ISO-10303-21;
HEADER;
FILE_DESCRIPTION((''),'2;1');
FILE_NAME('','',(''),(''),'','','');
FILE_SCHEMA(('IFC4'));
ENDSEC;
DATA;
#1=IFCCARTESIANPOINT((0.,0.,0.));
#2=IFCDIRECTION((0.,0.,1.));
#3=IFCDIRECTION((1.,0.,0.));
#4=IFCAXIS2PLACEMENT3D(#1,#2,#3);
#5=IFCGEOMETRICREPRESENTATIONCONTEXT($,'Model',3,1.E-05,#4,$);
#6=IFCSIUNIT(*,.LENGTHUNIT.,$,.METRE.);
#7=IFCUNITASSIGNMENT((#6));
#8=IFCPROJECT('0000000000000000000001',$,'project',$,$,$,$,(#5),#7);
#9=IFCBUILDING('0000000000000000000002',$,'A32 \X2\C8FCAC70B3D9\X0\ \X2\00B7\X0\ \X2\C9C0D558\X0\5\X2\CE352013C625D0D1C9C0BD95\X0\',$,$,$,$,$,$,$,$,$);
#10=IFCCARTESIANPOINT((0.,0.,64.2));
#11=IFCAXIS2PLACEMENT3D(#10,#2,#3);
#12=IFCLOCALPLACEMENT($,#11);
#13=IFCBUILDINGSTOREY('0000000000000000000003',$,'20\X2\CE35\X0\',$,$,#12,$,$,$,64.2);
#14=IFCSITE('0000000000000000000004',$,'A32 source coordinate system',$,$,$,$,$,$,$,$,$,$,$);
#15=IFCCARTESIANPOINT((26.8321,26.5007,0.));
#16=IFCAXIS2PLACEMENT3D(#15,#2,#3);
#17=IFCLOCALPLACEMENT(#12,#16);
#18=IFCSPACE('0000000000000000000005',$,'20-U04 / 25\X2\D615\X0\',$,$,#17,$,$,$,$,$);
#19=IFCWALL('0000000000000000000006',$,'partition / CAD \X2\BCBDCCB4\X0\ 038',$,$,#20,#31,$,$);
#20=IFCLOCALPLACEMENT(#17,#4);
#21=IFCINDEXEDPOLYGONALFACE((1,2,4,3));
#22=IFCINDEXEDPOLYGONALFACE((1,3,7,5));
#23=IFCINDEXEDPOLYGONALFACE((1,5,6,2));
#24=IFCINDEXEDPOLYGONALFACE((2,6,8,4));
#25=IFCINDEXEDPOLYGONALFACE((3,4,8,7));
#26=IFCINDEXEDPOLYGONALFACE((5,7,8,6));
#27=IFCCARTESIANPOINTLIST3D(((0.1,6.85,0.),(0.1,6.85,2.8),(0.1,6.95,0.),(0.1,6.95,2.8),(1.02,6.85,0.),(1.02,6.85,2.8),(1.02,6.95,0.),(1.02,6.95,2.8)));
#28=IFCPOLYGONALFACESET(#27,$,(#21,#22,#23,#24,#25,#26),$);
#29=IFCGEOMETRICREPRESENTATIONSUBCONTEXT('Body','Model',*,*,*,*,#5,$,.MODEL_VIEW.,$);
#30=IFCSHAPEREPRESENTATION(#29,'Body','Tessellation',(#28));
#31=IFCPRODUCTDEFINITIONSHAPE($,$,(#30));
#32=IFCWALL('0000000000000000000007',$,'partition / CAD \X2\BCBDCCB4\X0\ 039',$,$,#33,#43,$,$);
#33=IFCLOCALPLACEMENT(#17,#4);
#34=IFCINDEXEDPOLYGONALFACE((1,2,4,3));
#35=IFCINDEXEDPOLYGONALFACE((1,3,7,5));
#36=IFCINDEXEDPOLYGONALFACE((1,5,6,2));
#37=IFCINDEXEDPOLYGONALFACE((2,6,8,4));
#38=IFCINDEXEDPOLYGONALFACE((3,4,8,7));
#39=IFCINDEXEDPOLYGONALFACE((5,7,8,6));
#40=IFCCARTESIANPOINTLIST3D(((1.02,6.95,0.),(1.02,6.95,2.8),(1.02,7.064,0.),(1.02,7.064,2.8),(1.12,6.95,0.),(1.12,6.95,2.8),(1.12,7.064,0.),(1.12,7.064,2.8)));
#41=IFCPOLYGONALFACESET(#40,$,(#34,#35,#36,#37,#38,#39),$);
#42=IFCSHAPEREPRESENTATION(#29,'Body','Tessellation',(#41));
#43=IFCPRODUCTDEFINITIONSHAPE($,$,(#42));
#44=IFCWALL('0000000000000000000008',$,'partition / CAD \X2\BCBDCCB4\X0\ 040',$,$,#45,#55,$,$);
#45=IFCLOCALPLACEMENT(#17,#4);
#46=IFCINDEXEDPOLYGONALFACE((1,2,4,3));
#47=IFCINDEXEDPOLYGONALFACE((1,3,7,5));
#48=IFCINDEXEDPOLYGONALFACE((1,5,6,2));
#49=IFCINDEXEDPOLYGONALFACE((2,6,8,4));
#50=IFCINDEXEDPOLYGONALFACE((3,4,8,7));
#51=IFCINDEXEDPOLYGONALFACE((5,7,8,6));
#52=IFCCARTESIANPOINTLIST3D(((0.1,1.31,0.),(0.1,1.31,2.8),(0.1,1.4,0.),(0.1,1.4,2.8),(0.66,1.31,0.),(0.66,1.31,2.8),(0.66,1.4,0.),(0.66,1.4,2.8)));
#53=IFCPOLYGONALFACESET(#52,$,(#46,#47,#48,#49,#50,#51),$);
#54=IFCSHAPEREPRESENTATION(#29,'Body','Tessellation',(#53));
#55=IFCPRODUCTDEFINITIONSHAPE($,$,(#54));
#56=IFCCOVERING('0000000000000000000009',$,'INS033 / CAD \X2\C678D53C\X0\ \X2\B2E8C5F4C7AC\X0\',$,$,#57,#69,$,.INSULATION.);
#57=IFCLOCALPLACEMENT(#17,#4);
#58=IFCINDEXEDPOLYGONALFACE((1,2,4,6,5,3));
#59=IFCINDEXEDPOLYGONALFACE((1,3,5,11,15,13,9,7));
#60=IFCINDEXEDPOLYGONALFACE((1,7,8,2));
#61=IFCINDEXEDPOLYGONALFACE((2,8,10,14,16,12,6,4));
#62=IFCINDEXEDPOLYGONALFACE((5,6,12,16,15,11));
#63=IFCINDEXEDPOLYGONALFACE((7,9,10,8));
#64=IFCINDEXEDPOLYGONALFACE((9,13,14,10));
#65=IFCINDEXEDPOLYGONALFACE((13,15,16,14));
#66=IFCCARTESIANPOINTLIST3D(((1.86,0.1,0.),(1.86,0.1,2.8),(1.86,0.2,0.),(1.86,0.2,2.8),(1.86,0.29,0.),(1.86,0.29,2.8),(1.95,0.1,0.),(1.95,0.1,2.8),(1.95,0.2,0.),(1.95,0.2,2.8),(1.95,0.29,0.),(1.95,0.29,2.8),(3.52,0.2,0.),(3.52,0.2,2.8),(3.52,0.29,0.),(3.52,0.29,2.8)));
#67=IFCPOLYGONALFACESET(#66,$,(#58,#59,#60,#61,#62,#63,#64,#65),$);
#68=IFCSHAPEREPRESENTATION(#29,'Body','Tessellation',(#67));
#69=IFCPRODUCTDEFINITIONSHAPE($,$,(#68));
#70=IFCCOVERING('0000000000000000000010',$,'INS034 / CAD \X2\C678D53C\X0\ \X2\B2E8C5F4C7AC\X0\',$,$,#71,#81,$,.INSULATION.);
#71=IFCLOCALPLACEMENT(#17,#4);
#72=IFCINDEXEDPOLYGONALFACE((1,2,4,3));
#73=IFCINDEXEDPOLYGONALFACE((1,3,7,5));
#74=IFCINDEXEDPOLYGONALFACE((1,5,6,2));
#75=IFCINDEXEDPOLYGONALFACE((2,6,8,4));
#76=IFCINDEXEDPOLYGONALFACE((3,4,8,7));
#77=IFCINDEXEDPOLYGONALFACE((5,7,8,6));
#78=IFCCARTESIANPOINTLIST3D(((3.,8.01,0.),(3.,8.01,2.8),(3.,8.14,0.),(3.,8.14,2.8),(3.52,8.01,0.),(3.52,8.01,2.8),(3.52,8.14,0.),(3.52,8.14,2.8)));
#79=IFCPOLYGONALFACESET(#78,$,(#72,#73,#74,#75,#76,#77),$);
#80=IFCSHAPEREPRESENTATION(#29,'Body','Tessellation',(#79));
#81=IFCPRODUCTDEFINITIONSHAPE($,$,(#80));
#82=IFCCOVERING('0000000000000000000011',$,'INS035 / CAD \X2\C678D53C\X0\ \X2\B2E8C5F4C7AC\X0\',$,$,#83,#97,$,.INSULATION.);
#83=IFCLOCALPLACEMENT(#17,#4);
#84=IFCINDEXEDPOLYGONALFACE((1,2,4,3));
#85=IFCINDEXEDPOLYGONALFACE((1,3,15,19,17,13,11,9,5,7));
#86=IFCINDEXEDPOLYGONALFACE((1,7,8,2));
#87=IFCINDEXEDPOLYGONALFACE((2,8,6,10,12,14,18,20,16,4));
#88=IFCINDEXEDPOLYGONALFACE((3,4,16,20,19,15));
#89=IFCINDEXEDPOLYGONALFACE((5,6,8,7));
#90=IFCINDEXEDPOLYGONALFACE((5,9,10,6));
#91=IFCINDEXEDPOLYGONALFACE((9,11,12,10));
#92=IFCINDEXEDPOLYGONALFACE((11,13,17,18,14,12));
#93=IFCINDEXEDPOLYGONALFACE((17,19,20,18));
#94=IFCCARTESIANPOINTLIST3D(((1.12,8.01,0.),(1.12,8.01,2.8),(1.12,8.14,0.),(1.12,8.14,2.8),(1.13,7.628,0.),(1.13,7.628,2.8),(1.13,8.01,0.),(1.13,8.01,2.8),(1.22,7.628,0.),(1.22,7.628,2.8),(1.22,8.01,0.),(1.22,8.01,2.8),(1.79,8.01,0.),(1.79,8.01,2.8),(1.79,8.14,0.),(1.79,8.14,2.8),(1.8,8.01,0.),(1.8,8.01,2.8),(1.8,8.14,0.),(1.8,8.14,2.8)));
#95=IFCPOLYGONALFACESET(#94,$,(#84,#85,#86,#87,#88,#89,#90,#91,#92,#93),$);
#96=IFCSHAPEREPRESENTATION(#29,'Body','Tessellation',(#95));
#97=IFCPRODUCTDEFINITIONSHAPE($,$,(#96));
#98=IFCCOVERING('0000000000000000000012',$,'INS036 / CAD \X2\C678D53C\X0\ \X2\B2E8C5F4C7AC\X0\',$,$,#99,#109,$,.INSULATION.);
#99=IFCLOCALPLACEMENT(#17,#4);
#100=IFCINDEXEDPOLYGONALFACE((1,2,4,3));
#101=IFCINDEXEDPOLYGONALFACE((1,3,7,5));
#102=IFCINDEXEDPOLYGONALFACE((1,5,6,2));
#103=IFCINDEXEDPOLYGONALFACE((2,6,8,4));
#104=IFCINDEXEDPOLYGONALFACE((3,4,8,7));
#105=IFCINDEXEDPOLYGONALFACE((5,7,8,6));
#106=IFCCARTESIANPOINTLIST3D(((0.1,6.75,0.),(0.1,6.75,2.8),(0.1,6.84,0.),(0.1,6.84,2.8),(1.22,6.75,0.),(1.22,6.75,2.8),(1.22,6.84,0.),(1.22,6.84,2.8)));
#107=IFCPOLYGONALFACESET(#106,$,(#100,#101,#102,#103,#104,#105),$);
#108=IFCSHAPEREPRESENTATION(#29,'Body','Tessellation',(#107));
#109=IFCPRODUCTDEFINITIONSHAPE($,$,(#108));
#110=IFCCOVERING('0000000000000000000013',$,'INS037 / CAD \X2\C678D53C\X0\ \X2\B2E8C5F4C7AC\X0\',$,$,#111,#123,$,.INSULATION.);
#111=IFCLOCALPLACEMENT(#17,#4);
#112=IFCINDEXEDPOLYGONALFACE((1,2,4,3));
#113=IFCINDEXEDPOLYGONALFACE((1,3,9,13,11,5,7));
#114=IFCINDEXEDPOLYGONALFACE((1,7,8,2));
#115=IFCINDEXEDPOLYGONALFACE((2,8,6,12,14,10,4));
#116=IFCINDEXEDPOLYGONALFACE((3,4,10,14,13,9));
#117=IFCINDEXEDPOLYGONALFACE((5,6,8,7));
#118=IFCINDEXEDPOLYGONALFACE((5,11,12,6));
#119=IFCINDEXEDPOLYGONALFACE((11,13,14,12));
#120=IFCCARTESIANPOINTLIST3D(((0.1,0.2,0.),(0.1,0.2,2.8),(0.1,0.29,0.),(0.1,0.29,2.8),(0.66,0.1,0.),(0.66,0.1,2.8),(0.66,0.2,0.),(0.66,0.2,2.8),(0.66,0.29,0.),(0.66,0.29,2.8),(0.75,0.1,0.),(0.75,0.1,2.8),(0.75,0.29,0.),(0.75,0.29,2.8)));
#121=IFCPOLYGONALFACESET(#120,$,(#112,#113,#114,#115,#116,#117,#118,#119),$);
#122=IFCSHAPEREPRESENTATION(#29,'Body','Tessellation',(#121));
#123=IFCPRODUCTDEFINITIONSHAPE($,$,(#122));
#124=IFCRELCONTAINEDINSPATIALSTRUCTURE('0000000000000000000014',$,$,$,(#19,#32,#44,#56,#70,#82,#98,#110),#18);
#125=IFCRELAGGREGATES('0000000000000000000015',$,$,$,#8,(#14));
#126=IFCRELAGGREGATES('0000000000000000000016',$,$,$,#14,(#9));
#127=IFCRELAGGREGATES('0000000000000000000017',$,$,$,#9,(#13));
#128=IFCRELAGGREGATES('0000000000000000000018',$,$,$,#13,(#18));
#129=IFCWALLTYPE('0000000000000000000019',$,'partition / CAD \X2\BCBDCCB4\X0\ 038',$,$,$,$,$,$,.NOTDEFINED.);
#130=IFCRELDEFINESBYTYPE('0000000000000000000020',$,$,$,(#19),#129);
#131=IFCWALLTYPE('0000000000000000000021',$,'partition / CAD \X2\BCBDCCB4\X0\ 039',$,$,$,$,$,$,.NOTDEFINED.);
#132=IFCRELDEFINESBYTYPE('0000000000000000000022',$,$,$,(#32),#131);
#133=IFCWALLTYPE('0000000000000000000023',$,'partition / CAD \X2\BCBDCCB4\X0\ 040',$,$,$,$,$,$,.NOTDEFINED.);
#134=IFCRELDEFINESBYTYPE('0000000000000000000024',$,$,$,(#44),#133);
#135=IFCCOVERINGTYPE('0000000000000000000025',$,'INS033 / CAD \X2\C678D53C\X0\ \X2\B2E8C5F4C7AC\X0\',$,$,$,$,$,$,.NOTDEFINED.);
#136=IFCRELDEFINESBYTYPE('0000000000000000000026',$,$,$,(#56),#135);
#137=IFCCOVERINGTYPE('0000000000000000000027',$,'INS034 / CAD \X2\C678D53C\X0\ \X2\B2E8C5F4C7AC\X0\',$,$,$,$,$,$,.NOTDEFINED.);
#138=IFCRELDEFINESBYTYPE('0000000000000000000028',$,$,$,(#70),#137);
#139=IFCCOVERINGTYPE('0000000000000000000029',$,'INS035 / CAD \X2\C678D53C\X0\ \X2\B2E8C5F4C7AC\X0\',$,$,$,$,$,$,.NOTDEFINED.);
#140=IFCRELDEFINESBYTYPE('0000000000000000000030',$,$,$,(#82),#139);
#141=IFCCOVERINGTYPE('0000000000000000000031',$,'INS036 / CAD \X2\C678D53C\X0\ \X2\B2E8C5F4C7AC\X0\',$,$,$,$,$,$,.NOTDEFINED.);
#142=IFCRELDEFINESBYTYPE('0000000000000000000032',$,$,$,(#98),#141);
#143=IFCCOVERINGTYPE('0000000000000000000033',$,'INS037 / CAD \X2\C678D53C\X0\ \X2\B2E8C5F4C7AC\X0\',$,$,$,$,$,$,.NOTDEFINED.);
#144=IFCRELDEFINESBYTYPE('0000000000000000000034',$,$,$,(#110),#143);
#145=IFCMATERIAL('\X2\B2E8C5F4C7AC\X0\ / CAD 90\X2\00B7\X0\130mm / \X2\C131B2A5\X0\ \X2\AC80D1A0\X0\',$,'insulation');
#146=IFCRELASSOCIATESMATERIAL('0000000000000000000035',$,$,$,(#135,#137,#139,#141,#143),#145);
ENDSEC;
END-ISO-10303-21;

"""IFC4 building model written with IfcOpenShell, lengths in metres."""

from ifc_helpers import new_model, si_unit, frame, origin, origin_with_axes, place, context, subcontext, project, spatial, polyline, outline, extrude, source, transform, mapped, material, type_object, type_shapes, element, save


model = new_model("IFC4")

# Units and contexts
model_context = context("Model", 3, precision=1e-05, world=origin_with_axes())
body_context = subcontext(model_context, "Body", "Model", "MODEL_VIEW")
ifc_project = project(units=[si_unit("LENGTHUNIT", "METRE")], contexts=[model_context])

# Site, building, storey, space
storey_placement = place(None, frame((0.0, 0.0, 64.2), z_axis=(0.0, 0.0, 1.0), x_axis=(1.0, 0.0, 0.0)))
space_placement = place(storey_placement, frame((26.8321, 26.5007, 0.0), z_axis=(0.0, 0.0, 1.0), x_axis=(1.0, 0.0, 0.0)))
site = spatial("IfcSite", under=ifc_project, Name="A32 source coordinate system")
building = spatial("IfcBuilding", under=site, Name="A32 주거동 · 지하5층–옥탑지붕")
storey = spatial("IfcBuildingStorey", under=building, at=storey_placement, Name="20층", Elevation=64.2)
space = spatial("IfcSpace", under=storey, at=space_placement, Name="20-U04 / 25형")

# Walls
wall_type_1 = type_object("IfcWallType", Name="partition / CAD 벽체 038", PredefinedType="NOTDEFINED")
shared_shape_1 = source(origin(), body_context, "Body", "SweptSolid", [
    extrude(outline(polyline([(0.1, 6.95), (1.02, 6.95), (1.02, 6.85), (0.1, 6.85), (0.1, 6.95)])), origin(), (0.0, 0.0, 1.0), 2.8),
])
type_shapes(wall_type_1, [shared_shape_1])
wall_1_placement = place(space_placement, origin_with_axes())
element("IfcWall", 1, at=wall_1_placement, inside=space, type_object=wall_type_1, Name="partition / CAD 벽체 038", context=body_context, shape_type="MappedRepresentation", body=[
    mapped(shared_shape_1, transform((0.0, 0.0, 0.0), scale=1.0)),
])
wall_type_2 = type_object("IfcWallType", Name="partition / CAD 벽체 039", PredefinedType="NOTDEFINED")
shared_shape_2 = source(origin(), body_context, "Body", "SweptSolid", [
    extrude(outline(polyline([(1.02, 6.95), (1.02, 7.064), (1.12, 7.064), (1.12, 6.95), (1.02, 6.95)])), origin(), (0.0, 0.0, 1.0), 2.8),
])
type_shapes(wall_type_2, [shared_shape_2])
wall_2_placement = place(space_placement, origin_with_axes())
element("IfcWall", 2, at=wall_2_placement, inside=space, type_object=wall_type_2, Name="partition / CAD 벽체 039", context=body_context, shape_type="MappedRepresentation", body=[
    mapped(shared_shape_2, transform((0.0, 0.0, 0.0), scale=1.0)),
])
wall_type_3 = type_object("IfcWallType", Name="partition / CAD 벽체 040", PredefinedType="NOTDEFINED")
shared_shape_3 = source(origin(), body_context, "Body", "SweptSolid", [
    extrude(outline(polyline([(0.1, 1.4), (0.66, 1.4), (0.66, 1.31), (0.1, 1.31), (0.1, 1.4)])), origin(), (0.0, 0.0, 1.0), 2.8),
])
type_shapes(wall_type_3, [shared_shape_3])
wall_3_placement = place(space_placement, origin_with_axes())
element("IfcWall", 3, at=wall_3_placement, inside=space, type_object=wall_type_3, Name="partition / CAD 벽체 040", context=body_context, shape_type="MappedRepresentation", body=[
    mapped(shared_shape_3, transform((0.0, 0.0, 0.0), scale=1.0)),
])

# Coverings
ifc_material = material(Name="단열재 / CAD 90·130mm / 성능 검토", Category="insulation")
covering_type_1 = type_object("IfcCoveringType", Name="INS033 / CAD 외피 단열재", PredefinedType="NOTDEFINED", material=ifc_material)
shared_shape_4 = source(origin(), body_context, "Body", "SweptSolid", [
    extrude(outline(polyline([(1.95, 0.29), (3.52, 0.29), (3.52, 0.2), (1.95, 0.2), (1.95, 0.1), (1.86, 0.1), (1.86, 0.2), (1.86, 0.29), (1.95, 0.29)])), origin(), (0.0, 0.0, 1.0), 2.8),
])
type_shapes(covering_type_1, [shared_shape_4])
covering_1_placement = place(space_placement, origin_with_axes())
element("IfcCovering", 4, at=covering_1_placement, inside=space, type_object=covering_type_1, Name="INS033 / CAD 외피 단열재", PredefinedType="INSULATION", context=body_context, shape_type="MappedRepresentation", body=[
    mapped(shared_shape_4, transform((0.0, 0.0, 0.0), scale=1.0)),
])
covering_type_2 = type_object("IfcCoveringType", Name="INS034 / CAD 외피 단열재", PredefinedType="NOTDEFINED", material=ifc_material)
shared_shape_5 = source(origin(), body_context, "Body", "SweptSolid", [
    extrude(outline(polyline([(3.52, 8.01), (3.0, 8.01), (3.0, 8.14), (3.52, 8.14), (3.52, 8.01)])), origin(), (0.0, 0.0, 1.0), 2.8),
])
type_shapes(covering_type_2, [shared_shape_5])
covering_2_placement = place(space_placement, origin_with_axes())
element("IfcCovering", 5, at=covering_2_placement, inside=space, type_object=covering_type_2, Name="INS034 / CAD 외피 단열재", PredefinedType="INSULATION", context=body_context, shape_type="MappedRepresentation", body=[
    mapped(shared_shape_5, transform((0.0, 0.0, 0.0), scale=1.0)),
])
covering_type_3 = type_object("IfcCoveringType", Name="INS035 / CAD 외피 단열재", PredefinedType="NOTDEFINED", material=ifc_material)
shared_shape_6 = source(origin(), body_context, "Body", "SweptSolid", [
    extrude(outline(polyline([(1.8, 8.01), (1.79, 8.01), (1.22, 8.01), (1.22, 7.628), (1.13, 7.628), (1.13, 8.01), (1.12, 8.01), (1.12, 8.14), (1.79, 8.14), (1.8, 8.14), (1.8, 8.01)])), origin(), (0.0, 0.0, 1.0), 2.8),
])
type_shapes(covering_type_3, [shared_shape_6])
covering_3_placement = place(space_placement, origin_with_axes())
element("IfcCovering", 6, at=covering_3_placement, inside=space, type_object=covering_type_3, Name="INS035 / CAD 외피 단열재", PredefinedType="INSULATION", context=body_context, shape_type="MappedRepresentation", body=[
    mapped(shared_shape_6, transform((0.0, 0.0, 0.0), scale=1.0)),
])
covering_type_4 = type_object("IfcCoveringType", Name="INS036 / CAD 외피 단열재", PredefinedType="NOTDEFINED", material=ifc_material)
shared_shape_7 = source(origin(), body_context, "Body", "SweptSolid", [
    extrude(outline(polyline([(1.22, 6.84), (1.22, 6.75), (0.1, 6.75), (0.1, 6.84), (1.22, 6.84)])), origin(), (0.0, 0.0, 1.0), 2.8),
])
type_shapes(covering_type_4, [shared_shape_7])
covering_4_placement = place(space_placement, origin_with_axes())
element("IfcCovering", 7, at=covering_4_placement, inside=space, type_object=covering_type_4, Name="INS036 / CAD 외피 단열재", PredefinedType="INSULATION", context=body_context, shape_type="MappedRepresentation", body=[
    mapped(shared_shape_7, transform((0.0, 0.0, 0.0), scale=1.0)),
])
covering_type_5 = type_object("IfcCoveringType", Name="INS037 / CAD 외피 단열재", PredefinedType="NOTDEFINED", material=ifc_material)
shared_shape_8 = source(origin(), body_context, "Body", "SweptSolid", [
    extrude(outline(polyline([(0.1, 0.2), (0.1, 0.29), (0.66, 0.29), (0.75, 0.29), (0.75, 0.1), (0.66, 0.1), (0.66, 0.2), (0.1, 0.2)])), origin(), (0.0, 0.0, 1.0), 2.8),
])
type_shapes(covering_type_5, [shared_shape_8])
covering_5_placement = place(space_placement, origin_with_axes())
element("IfcCovering", 8, at=covering_5_placement, inside=space, type_object=covering_type_5, Name="INS037 / CAD 외피 단열재", PredefinedType="INSULATION", context=body_context, shape_type="MappedRepresentation", body=[
    mapped(shared_shape_8, transform((0.0, 0.0, 0.0), scale=1.0)),
])

save(model, "model.ifc")
